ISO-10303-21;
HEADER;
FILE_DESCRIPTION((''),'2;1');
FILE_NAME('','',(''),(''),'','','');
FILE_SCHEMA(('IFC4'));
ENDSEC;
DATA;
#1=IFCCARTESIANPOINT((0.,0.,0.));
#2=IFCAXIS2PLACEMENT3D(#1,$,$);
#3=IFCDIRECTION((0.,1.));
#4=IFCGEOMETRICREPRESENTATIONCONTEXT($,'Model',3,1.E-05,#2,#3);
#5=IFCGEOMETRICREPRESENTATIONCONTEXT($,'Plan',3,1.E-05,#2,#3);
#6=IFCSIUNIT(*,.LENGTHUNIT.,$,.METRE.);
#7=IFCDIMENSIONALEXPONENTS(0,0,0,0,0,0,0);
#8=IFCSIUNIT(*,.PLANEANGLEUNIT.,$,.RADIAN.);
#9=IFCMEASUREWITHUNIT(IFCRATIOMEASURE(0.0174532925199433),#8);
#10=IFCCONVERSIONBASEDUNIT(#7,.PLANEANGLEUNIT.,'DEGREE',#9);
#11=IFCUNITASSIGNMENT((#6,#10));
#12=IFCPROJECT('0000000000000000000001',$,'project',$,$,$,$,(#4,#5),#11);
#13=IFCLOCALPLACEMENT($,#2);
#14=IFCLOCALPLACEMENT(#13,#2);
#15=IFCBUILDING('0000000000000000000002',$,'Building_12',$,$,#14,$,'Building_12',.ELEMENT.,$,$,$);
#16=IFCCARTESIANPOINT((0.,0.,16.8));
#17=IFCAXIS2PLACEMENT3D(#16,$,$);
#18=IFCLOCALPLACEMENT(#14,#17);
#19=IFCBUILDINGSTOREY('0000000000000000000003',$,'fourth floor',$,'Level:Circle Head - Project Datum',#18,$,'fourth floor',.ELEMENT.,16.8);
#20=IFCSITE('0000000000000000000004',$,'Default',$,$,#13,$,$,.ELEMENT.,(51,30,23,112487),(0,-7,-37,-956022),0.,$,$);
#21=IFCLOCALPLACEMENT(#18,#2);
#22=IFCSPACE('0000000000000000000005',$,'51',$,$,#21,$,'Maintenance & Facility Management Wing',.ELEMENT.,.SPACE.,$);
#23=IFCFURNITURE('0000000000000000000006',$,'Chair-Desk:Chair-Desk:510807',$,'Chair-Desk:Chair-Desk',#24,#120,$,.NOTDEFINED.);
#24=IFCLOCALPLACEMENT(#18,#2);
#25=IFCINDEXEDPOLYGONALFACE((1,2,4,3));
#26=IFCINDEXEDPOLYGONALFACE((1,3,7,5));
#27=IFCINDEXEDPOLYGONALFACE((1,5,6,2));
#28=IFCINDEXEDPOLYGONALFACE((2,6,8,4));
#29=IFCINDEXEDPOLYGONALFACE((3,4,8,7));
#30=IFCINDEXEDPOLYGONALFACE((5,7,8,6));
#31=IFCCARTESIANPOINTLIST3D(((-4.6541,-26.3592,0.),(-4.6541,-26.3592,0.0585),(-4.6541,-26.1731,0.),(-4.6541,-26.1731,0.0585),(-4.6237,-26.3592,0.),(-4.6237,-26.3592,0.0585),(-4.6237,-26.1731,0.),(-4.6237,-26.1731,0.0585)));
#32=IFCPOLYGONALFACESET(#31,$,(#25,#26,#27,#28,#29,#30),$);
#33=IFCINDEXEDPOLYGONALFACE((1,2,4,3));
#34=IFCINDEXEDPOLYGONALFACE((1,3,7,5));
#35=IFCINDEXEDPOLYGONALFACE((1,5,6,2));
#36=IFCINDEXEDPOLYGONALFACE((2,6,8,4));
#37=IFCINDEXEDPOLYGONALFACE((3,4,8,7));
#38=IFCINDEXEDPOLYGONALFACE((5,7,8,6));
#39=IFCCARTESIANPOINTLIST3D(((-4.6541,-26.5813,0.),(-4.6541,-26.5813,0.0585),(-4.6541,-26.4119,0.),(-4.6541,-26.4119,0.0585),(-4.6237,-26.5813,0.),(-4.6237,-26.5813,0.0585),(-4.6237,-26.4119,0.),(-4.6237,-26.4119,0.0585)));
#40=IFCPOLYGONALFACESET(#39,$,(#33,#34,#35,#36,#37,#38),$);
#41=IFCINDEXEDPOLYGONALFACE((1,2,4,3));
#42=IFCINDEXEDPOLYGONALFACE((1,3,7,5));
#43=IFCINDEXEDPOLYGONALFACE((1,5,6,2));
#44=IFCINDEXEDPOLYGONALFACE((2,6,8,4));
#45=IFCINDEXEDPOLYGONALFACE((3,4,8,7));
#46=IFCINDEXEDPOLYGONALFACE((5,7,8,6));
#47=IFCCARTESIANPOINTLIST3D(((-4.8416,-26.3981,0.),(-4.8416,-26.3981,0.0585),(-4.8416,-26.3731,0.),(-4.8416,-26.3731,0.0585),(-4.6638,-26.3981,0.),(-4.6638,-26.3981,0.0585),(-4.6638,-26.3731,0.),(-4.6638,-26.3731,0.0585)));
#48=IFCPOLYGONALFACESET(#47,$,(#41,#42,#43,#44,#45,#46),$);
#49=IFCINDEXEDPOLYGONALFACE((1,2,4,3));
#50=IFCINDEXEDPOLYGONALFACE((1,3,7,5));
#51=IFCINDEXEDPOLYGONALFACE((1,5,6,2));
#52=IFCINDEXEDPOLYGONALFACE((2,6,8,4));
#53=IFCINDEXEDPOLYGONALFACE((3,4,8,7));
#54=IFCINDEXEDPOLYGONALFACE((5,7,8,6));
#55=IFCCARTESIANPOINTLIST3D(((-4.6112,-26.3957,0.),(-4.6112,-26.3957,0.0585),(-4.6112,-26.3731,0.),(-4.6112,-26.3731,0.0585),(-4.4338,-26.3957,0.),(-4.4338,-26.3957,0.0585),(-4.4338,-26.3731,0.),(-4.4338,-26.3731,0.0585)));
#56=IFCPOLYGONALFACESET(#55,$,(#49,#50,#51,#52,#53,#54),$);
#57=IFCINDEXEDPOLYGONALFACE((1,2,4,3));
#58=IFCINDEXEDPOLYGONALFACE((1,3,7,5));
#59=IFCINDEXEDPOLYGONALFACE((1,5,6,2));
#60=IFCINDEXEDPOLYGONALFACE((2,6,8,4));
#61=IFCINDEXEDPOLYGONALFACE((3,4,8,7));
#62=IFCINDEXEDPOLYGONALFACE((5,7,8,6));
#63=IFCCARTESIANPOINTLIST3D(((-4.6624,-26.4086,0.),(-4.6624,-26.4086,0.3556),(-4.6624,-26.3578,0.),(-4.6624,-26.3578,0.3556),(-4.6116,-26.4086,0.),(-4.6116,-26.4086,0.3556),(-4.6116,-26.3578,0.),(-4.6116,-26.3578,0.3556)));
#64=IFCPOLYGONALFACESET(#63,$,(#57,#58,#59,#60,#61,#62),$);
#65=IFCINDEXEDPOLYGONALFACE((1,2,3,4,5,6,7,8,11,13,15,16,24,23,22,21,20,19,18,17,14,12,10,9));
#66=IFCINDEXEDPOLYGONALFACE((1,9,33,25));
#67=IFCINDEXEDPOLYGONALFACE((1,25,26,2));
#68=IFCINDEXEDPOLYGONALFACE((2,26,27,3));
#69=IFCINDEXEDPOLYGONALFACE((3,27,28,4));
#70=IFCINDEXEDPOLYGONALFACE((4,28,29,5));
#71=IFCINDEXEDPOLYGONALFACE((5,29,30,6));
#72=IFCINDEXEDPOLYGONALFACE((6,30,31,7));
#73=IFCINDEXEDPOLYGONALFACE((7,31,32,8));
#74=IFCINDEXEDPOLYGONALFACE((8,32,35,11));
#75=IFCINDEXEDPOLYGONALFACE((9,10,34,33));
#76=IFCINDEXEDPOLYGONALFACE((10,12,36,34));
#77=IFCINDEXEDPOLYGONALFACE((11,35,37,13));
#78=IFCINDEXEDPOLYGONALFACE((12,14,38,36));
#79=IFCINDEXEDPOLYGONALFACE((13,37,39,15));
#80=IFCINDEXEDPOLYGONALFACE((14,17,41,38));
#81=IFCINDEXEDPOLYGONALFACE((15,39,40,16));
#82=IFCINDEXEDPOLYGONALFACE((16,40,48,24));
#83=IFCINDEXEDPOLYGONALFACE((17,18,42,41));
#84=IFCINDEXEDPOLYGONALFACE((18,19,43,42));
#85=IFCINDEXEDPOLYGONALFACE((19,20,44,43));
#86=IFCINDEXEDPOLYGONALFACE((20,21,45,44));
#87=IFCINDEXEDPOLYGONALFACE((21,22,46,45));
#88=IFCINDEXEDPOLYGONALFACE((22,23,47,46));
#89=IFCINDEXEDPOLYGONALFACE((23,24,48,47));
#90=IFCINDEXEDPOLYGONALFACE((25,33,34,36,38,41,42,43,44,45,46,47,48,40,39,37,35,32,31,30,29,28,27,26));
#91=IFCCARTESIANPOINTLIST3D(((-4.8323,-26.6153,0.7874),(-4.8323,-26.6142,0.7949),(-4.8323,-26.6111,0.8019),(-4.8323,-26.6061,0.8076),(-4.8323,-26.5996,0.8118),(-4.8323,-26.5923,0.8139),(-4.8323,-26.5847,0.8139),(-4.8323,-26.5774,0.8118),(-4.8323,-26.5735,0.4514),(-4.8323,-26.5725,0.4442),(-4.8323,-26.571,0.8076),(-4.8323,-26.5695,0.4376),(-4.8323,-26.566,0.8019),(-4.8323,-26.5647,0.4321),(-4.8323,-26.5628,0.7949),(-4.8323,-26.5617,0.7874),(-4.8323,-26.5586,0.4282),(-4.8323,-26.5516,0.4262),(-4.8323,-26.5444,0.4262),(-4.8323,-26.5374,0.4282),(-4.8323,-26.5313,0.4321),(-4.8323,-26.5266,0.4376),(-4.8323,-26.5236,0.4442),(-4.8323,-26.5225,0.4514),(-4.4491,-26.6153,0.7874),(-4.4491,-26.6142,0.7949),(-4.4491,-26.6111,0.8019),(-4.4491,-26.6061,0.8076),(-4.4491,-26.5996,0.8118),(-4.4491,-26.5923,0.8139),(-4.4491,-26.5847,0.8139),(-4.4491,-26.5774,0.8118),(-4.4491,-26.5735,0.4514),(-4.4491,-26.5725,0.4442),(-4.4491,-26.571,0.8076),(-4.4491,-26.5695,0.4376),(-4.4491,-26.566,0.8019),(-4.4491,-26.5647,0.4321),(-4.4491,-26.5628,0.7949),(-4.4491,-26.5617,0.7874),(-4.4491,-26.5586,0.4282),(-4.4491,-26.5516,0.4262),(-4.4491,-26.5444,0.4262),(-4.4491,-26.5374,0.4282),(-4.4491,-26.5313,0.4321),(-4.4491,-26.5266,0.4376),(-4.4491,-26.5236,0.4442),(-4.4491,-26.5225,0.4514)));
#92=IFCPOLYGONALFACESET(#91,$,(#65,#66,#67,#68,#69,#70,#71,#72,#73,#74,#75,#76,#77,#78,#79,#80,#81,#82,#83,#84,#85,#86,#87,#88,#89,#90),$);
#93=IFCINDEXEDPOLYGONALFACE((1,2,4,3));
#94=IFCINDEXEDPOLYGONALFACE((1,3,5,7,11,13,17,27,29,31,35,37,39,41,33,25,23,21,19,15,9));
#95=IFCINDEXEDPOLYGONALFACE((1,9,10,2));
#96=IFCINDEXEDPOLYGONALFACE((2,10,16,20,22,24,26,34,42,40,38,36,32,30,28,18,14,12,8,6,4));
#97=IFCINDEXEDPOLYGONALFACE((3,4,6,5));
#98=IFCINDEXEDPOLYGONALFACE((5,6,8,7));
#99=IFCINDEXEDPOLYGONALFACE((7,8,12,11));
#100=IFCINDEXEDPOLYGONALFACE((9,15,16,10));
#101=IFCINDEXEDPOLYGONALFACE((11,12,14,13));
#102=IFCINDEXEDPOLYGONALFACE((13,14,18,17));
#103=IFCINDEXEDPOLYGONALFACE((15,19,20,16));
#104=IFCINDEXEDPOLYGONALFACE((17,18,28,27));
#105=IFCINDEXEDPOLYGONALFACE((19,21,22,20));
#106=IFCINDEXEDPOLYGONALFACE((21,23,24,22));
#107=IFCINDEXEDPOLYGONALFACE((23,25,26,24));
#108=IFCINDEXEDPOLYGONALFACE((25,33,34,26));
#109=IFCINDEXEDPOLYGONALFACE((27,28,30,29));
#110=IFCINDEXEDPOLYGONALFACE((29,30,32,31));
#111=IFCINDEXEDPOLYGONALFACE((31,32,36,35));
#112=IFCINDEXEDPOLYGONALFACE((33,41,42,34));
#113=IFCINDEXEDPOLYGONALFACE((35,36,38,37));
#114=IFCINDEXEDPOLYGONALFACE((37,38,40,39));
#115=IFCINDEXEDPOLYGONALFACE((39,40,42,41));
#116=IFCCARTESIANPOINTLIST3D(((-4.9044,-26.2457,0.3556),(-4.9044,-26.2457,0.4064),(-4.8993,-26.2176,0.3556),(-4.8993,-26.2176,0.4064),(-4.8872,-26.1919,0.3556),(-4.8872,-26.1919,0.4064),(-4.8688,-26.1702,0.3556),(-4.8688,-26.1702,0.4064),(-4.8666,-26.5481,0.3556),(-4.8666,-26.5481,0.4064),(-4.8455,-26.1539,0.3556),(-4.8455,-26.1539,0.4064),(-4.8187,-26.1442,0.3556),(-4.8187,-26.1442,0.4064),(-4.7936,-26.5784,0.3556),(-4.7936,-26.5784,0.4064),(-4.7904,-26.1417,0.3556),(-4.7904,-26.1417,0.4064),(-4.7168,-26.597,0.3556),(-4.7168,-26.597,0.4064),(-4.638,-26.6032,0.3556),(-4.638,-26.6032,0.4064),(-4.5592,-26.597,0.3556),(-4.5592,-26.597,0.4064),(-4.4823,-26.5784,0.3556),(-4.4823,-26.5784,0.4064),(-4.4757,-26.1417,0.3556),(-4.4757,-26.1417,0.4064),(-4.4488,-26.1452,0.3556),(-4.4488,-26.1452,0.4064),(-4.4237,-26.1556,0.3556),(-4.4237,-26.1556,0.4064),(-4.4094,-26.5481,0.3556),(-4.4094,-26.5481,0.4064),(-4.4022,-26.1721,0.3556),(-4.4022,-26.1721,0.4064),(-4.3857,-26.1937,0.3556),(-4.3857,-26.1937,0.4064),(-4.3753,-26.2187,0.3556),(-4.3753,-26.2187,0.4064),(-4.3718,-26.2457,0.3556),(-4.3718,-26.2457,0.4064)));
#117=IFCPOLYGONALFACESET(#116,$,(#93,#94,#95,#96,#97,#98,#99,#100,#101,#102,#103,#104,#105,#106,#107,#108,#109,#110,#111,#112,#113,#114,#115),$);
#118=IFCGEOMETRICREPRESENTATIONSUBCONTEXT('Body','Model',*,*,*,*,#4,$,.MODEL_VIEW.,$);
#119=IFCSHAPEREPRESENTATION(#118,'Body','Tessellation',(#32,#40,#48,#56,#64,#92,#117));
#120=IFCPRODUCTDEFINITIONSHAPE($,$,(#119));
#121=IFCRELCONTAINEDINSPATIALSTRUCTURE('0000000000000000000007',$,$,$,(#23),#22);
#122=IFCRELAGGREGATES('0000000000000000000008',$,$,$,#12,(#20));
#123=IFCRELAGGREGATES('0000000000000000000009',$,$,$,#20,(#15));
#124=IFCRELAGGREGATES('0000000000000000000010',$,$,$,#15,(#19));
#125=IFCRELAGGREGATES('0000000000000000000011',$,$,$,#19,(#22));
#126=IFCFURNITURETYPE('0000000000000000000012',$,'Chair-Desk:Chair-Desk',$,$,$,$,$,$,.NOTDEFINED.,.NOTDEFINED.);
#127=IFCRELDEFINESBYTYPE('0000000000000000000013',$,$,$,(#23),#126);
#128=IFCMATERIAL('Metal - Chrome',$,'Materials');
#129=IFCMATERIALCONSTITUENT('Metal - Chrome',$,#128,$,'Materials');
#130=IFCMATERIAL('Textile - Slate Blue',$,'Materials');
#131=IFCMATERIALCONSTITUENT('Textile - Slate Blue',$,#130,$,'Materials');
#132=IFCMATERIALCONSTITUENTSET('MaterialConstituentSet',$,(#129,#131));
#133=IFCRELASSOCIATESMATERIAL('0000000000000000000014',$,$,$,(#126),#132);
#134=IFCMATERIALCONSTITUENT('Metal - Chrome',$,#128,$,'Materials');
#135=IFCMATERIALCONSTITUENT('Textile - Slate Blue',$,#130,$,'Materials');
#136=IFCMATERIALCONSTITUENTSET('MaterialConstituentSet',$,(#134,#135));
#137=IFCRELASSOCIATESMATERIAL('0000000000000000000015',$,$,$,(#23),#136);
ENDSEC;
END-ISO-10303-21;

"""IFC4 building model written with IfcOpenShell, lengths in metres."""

from ifc_helpers import new_model, entity, si_unit, converted_unit, direction, frame, origin, place, context, subcontext, project, spatial, line, arc, indexed_curve, outline, extrude, source, transform, mapped, material, constituent, constituent_set, type_object, type_shapes, element, save


model = new_model("IFC4")

# Units and contexts
model_context = context("Model", 3, precision=1e-05, world=origin(), true_north=direction((0.0, 1.0)))
plan_context = context("Plan", 3, precision=1e-05, world=origin(), true_north=direction((0.0, 1.0)))
body_context = subcontext(model_context, "Body", "Model", "MODEL_VIEW")
ifc_project = project(units=[si_unit("LENGTHUNIT", "METRE"), converted_unit("PLANEANGLEUNIT", "DEGREE", entity("IfcRatioMeasure", 0.0174532925199433), si_unit("PLANEANGLEUNIT", "RADIAN"), dimensions=[0, 0, 0, 0, 0, 0, 0])], contexts=[model_context, plan_context])

# Site, building, storey
site_placement = place(None, origin())
site = spatial("IfcSite", under=ifc_project, at=site_placement, Name="Default", CompositionType="ELEMENT", RefLatitude=(51, 30, 23, 112487), RefLongitude=(0, -7, -37, -956022), RefElevation=0.0)
building_placement = place(site_placement, origin())
building = spatial("IfcBuilding", under=site, at=building_placement, Name="Building_12", LongName="Building_12", CompositionType="ELEMENT")
storey_placement = place(building_placement, frame((0.0, 0.0, 16.8)))
storey = spatial("IfcBuildingStorey", under=building, at=storey_placement, Name="fourth floor", ObjectType="Level:Circle Head - Project Datum", LongName="fourth floor", CompositionType="ELEMENT", Elevation=16.8)

# Shared definitions
space_placement = place(storey_placement, origin())
space = spatial("IfcSpace", under=storey, at=space_placement, Name="51", LongName="Maintenance & Facility Management Wing", CompositionType="ELEMENT", PredefinedType="SPACE")

# Furniture
ifc_material_1 = material(Name="Metal - Chrome", Category="Materials")
ifc_material_2 = material(Name="Textile - Slate Blue", Category="Materials")
ifc_constituent_1 = constituent(ifc_material_1, Name="Metal - Chrome", Category="Materials")
ifc_constituent_2 = constituent(ifc_material_2, Name="Textile - Slate Blue", Category="Materials")
ifc_constituent_set_1 = constituent_set(constituents=[ifc_constituent_1, ifc_constituent_2], Name="MaterialConstituentSet")
furniture_type = type_object("IfcFurnitureType", Name="Chair-Desk:Chair-Desk", AssemblyPlace="NOTDEFINED", PredefinedType="NOTDEFINED", material=ifc_constituent_set_1)
shared_shape = source(origin(), body_context, "Body", "SweptSolid", [
    extrude(outline(indexed_curve([(-0.0152, -0.093), (0.0152, -0.093), (0.0152, 0.093), (-0.0152, 0.093), (-0.0152, -0.093)], self_intersect=False)), frame((-0.0009, 0.2819, 0.0)), (0.0, 0.0, 1.0), 0.0585),
    extrude(outline(indexed_curve([(-0.0152, -0.0847), (0.0152, -0.0847), (0.0152, 0.0847), (-0.0152, 0.0847), (-0.0152, -0.0847)], self_intersect=False)), frame((-0.0009, 0.0515, 0.0), z_axis=(0.0, 0.0, 1.0), x_axis=(-1.0, 0.0, 0.0)), (0.0, 0.0, 1.0), 0.0585),
    extrude(outline(indexed_curve([(-0.0125, -0.0889), (0.0125, -0.0889), (0.0125, 0.0889), (-0.0125, 0.0889), (-0.0125, -0.0889)], self_intersect=False)), frame((-0.1148, 0.1625, 0.0), z_axis=(0.0, 0.0, 1.0), x_axis=(0.0, -1.0, 0.0)), (0.0, 0.0, 1.0), 0.0585),
    extrude(outline(indexed_curve([(-0.0887, -0.0113), (0.0887, -0.0113), (0.0887, 0.0113), (-0.0887, 0.0113), (-0.0887, -0.0113)], self_intersect=False)), frame((0.1155, 0.1637, 0.0), z_axis=(0.0, 0.0, 1.0), x_axis=(-1.0, 0.0, 0.0)), (0.0, 0.0, 1.0), 0.0585),
    extrude(outline(indexed_curve([(-0.0254, -0.0254), (0.0254, -0.0254), (0.0254, 0.0254), (-0.0254, 0.0254), (-0.0254, -0.0254)], self_intersect=False)), frame((0.0009, 0.1649, 0.0), z_axis=(0.0, 0.0, 1.0), x_axis=(-1.0, 0.0, 0.0)), (0.0, 0.0, 1.0), 0.3556),
    extrude(outline(indexed_curve([(0.0065, 0.168), (-0.0202, 0.1948), (-0.047, 0.168), (-0.0052, -0.168), (0.0202, -0.1935), (0.0457, -0.168)], segments=[arc(1, 2, 3), line(3, 4), arc(4, 5, 6), line(6, 1)], self_intersect=False)), frame((-0.1944, -0.0202, 0.6194), z_axis=(1.0, 0.0, 0.0), x_axis=(0.0, 1.0, 0.0)), (0.0, 0.0, 1.0), 0.3833),
    extrude(outline(indexed_curve([(-0.0989, -0.2577), (0.2059, -0.2577), (0.2889, -0.0377), (0.2626, 0.1959), (-0.0328, 0.2708), (-0.1095, 0.2497), (-0.1489, 0.1805), (-0.1879, -0.1317), (-0.1694, -0.2131)], segments=[line(1, 2), arc(2, 3, 4), line(4, 5), arc(5, 6, 7), line(7, 8), arc(8, 9, 1)], self_intersect=False)), frame((0.0016, 0.2363, 0.3556), z_axis=(0.0, 0.0, 1.0), x_axis=(0.124035, -0.992278, 0.0)), (0.0, 0.0, 1.0), 0.0508),
])
type_shapes(furniture_type, [shared_shape])
ifc_constituent_3 = constituent(ifc_material_1, Name="Metal - Chrome", Category="Materials")
ifc_constituent_4 = constituent(ifc_material_2, Name="Textile - Slate Blue", Category="Materials")
ifc_constituent_set_2 = constituent_set(constituents=[ifc_constituent_3, ifc_constituent_4], Name="MaterialConstituentSet")
furniture_1_placement = place(space_placement, frame((-4.638, -26.5481, 0.0)))
element("IfcFurniture", 1, at=furniture_1_placement, inside=space, type_object=furniture_type, material=ifc_constituent_set_2, Name="Chair-Desk:Chair-Desk:510807", ObjectType="Chair-Desk:Chair-Desk", PredefinedType="NOTDEFINED", context=body_context, shape_type="MappedRepresentation", body=[
    mapped(shared_shape, transform((0.0, 0.0, 0.0), scale=1.0)),
])

save(model, "model.ifc")
